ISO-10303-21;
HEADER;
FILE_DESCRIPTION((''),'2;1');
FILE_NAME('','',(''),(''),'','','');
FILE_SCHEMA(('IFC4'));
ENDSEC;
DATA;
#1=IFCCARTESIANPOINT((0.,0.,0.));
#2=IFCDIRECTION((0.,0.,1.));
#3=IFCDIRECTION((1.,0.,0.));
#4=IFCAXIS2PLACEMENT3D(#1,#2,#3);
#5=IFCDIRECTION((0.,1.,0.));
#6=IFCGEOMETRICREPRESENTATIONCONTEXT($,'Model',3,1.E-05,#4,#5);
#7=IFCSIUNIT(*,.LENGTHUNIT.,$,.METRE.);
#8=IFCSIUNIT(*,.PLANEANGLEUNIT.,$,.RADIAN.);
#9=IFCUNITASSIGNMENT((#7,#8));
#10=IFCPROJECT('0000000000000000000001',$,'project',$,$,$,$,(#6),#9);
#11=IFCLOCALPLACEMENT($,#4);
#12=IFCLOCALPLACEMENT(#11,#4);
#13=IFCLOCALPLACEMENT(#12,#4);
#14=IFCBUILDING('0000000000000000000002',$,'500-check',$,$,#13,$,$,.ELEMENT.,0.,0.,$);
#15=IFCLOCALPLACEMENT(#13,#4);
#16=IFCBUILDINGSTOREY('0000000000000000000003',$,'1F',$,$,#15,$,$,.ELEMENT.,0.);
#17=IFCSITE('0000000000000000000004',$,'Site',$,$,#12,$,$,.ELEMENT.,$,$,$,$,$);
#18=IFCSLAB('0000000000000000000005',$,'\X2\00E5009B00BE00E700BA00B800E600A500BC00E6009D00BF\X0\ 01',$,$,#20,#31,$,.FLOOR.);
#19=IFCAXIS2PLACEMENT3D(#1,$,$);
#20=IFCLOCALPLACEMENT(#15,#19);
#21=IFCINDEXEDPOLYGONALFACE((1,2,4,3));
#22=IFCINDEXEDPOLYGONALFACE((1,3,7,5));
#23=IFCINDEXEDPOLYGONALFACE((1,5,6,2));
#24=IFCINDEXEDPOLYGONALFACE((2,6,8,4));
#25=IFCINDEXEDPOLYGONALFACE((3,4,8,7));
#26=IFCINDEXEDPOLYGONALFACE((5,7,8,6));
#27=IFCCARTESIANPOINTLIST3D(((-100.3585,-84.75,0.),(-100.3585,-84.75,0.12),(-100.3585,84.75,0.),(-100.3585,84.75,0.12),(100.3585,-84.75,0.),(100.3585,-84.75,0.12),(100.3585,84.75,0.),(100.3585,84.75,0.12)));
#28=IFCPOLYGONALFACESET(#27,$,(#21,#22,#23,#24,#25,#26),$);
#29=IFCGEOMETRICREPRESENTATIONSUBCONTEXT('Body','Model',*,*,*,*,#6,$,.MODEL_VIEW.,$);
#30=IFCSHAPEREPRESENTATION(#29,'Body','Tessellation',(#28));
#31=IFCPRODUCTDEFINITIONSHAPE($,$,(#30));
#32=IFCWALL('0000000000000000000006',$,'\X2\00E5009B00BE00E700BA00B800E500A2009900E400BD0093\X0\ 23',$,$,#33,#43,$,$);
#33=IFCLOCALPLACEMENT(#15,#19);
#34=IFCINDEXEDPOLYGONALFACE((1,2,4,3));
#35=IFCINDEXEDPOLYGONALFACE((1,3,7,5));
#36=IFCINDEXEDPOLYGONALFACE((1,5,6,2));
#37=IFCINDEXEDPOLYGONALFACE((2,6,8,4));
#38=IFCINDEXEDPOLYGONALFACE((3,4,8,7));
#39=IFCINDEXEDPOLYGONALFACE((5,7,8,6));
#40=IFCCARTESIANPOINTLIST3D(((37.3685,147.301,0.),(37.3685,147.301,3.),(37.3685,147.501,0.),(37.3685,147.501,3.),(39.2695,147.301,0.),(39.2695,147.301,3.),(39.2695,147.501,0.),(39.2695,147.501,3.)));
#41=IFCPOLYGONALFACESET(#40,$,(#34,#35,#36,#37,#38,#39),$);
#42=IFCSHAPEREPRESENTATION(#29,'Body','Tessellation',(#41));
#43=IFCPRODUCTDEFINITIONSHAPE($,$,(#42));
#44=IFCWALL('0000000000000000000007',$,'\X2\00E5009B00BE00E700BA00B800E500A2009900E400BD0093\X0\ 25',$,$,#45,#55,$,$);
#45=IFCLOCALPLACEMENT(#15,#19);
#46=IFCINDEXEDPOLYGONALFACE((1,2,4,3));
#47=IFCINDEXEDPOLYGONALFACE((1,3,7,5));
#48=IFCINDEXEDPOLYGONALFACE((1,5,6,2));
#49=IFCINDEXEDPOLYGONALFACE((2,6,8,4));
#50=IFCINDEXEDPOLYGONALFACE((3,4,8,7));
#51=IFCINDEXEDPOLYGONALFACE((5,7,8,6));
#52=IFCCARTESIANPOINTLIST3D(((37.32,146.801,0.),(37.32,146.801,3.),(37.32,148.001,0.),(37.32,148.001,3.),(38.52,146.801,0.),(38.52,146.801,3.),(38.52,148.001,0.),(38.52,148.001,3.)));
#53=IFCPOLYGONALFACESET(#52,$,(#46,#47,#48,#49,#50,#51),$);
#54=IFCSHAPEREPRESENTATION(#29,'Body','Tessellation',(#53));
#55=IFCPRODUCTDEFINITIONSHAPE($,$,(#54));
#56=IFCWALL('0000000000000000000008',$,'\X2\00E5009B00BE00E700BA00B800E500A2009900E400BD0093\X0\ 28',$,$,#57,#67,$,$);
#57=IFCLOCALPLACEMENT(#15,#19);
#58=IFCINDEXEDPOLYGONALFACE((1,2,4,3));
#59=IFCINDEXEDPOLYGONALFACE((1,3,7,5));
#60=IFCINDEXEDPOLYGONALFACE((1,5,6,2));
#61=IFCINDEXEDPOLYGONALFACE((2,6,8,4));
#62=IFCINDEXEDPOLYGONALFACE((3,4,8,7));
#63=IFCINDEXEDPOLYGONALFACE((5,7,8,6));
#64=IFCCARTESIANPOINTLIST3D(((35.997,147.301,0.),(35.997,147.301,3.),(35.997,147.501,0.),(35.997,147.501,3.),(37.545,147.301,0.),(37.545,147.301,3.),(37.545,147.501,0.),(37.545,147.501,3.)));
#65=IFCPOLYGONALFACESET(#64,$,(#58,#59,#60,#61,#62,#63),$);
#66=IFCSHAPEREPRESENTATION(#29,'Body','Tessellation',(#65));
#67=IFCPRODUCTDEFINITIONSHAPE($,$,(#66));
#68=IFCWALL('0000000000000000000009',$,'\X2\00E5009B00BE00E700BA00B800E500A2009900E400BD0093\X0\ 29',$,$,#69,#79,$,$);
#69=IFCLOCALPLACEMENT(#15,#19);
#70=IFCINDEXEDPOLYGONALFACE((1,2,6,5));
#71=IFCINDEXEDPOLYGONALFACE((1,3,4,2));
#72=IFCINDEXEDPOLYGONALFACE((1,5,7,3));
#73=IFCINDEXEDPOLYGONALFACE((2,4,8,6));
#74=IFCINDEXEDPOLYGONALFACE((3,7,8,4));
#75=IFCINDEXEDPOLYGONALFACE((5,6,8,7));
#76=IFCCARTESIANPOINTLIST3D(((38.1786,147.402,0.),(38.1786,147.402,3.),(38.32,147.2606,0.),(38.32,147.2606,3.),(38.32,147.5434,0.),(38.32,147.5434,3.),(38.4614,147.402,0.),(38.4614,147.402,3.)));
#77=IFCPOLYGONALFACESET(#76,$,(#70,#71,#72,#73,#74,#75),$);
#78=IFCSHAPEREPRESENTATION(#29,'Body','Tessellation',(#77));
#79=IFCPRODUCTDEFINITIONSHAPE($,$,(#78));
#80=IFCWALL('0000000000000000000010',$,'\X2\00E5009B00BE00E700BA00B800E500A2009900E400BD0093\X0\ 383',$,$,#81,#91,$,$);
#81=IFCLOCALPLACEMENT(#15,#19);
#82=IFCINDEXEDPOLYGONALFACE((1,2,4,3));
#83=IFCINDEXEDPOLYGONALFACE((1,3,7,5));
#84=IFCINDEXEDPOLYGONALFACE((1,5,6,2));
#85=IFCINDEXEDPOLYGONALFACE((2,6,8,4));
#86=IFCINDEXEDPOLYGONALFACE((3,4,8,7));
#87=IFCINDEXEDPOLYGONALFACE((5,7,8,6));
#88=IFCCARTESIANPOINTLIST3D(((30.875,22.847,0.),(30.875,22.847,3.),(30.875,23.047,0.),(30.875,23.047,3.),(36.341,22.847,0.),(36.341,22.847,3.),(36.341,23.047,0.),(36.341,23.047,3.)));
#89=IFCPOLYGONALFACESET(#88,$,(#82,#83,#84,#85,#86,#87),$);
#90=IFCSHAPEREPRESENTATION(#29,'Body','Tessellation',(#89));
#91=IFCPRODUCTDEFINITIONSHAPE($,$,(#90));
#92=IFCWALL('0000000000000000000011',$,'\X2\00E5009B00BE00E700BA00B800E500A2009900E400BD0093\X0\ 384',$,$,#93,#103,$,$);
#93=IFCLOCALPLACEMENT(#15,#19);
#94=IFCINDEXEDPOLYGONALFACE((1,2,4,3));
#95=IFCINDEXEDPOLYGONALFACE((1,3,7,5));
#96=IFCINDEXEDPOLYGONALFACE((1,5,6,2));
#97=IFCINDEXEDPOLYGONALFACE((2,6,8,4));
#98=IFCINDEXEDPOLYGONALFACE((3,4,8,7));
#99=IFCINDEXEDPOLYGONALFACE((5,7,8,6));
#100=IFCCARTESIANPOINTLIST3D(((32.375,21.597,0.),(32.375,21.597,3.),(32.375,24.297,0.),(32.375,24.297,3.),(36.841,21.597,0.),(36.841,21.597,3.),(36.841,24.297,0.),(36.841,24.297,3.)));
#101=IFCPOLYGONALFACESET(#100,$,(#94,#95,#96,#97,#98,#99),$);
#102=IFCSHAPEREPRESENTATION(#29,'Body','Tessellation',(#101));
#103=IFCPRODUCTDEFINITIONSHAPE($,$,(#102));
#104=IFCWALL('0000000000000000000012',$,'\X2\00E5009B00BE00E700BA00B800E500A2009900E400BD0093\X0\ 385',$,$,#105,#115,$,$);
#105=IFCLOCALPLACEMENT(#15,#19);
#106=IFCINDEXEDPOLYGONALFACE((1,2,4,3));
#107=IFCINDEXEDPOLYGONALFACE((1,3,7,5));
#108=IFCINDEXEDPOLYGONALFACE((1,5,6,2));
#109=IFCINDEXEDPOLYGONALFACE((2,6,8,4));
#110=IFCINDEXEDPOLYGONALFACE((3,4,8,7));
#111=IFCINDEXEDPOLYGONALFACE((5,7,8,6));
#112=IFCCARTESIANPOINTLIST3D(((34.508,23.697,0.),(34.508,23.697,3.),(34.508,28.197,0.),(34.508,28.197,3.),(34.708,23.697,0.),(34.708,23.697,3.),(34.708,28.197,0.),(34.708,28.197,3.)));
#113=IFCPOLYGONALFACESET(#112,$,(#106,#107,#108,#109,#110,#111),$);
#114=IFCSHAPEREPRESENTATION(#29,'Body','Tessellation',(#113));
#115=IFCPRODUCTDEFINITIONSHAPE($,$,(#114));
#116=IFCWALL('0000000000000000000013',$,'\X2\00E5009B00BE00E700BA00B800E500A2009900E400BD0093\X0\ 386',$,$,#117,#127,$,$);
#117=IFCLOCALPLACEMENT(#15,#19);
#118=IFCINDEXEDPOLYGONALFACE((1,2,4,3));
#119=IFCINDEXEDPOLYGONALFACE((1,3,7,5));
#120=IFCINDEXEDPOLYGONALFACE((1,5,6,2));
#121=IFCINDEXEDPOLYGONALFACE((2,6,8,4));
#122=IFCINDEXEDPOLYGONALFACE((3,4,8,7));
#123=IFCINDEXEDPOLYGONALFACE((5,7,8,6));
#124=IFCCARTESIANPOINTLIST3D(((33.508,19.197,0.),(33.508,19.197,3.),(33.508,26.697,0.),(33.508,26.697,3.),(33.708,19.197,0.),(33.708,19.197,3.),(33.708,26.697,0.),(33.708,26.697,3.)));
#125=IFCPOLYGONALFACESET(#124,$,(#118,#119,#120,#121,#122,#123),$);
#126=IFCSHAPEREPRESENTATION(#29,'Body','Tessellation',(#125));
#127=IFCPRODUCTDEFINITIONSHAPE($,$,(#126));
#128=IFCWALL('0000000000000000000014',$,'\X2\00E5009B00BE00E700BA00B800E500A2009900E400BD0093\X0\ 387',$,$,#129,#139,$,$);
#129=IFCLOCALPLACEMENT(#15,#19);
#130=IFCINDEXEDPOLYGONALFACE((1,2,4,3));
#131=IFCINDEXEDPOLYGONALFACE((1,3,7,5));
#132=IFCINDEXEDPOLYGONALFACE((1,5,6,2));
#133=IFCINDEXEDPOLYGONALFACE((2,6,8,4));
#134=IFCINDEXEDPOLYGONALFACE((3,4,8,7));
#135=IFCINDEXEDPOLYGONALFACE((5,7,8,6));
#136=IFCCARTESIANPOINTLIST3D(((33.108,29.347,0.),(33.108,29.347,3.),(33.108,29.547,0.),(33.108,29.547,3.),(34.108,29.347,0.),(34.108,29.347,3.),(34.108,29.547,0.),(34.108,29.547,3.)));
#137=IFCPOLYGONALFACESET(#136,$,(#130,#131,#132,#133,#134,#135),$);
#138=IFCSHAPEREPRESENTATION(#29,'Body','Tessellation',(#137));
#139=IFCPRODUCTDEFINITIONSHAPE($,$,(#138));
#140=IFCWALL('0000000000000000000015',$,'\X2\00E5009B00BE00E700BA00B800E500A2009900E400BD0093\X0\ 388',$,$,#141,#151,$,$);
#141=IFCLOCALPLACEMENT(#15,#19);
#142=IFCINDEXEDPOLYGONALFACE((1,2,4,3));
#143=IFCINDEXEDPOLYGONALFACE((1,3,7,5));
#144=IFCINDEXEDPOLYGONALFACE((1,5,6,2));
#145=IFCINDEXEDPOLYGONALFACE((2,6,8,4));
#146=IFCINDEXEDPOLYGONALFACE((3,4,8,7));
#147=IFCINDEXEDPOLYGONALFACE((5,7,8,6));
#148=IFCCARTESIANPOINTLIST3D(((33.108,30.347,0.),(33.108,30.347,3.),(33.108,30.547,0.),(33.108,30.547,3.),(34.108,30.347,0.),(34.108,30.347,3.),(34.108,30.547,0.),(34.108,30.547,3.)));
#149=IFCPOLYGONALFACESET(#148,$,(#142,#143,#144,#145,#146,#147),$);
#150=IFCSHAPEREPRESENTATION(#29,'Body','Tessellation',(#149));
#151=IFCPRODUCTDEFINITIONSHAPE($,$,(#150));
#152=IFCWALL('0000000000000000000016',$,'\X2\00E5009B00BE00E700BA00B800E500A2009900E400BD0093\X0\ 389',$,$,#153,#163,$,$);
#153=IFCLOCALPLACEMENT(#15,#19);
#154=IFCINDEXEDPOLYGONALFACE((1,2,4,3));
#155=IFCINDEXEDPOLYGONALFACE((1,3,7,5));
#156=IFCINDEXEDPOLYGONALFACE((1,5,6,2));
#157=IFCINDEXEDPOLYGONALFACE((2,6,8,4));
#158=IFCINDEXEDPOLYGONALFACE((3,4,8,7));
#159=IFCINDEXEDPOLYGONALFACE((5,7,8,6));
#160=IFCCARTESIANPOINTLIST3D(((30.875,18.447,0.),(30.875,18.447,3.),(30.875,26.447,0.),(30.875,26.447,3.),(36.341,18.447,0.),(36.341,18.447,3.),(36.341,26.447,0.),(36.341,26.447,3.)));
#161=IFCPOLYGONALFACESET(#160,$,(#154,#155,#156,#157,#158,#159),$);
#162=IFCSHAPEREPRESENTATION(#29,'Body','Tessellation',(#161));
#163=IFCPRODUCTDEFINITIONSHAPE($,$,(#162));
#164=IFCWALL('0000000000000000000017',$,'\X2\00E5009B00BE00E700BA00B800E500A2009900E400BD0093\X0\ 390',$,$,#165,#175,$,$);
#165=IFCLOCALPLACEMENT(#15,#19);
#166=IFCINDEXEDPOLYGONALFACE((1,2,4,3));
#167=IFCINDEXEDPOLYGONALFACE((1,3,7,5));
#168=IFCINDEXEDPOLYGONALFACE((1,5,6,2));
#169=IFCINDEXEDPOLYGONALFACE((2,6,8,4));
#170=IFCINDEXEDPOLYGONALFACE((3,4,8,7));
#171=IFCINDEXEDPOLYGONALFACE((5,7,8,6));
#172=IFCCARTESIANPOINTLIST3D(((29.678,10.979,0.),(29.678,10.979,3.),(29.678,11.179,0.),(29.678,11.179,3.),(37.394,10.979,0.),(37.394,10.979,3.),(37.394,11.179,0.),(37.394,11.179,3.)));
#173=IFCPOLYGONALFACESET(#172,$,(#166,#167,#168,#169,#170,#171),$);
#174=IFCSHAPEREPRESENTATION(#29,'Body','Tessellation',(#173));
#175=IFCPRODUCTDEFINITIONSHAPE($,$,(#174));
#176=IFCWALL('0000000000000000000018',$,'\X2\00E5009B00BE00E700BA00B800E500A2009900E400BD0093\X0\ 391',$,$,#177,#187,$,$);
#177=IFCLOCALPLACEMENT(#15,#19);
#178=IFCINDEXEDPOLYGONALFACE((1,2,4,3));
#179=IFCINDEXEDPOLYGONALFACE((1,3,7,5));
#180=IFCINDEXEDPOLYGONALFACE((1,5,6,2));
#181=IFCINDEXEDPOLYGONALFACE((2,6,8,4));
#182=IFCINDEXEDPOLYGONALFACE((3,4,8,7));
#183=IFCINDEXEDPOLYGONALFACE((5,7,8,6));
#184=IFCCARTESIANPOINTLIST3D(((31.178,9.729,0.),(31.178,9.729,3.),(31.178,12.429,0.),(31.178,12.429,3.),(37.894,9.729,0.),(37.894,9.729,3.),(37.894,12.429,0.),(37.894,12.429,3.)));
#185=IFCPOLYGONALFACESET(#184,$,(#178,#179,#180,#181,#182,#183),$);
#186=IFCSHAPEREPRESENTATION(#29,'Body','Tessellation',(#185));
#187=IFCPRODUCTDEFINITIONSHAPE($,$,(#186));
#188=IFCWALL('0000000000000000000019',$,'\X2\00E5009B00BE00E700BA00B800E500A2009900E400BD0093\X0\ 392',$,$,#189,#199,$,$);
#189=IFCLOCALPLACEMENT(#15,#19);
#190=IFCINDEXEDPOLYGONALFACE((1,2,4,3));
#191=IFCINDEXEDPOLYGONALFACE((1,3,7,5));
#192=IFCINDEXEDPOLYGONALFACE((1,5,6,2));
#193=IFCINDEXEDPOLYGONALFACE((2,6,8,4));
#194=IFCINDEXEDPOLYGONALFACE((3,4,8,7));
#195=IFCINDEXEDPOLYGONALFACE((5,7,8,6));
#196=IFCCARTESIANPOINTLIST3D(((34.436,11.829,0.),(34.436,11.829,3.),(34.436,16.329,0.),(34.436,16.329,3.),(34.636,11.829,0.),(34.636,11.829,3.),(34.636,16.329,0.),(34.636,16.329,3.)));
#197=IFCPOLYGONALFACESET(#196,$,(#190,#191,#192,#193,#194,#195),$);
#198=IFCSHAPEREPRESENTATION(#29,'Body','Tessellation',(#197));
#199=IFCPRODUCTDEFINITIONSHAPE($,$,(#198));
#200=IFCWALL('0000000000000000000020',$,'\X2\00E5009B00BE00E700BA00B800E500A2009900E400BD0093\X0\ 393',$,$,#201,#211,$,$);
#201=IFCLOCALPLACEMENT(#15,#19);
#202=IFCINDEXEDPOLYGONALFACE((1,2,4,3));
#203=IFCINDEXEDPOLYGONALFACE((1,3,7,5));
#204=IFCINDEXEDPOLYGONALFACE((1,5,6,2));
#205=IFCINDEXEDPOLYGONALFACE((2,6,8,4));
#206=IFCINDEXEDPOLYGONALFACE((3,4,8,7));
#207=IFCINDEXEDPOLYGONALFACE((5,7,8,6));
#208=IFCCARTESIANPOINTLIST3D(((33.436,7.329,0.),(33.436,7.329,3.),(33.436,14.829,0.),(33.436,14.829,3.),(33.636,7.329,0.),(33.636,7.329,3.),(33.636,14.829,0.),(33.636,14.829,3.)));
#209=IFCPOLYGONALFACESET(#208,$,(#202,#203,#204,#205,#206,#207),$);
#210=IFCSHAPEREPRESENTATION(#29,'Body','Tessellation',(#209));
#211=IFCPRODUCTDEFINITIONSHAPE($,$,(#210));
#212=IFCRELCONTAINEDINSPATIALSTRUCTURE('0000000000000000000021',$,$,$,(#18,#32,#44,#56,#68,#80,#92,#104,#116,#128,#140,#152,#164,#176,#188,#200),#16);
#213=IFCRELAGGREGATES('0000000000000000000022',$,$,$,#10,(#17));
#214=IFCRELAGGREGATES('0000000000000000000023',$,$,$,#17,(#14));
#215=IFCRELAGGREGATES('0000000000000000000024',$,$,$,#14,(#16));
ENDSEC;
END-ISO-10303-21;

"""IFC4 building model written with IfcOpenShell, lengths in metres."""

from ifc_helpers import new_model, si_unit, direction, frame, frame_2d, origin_with_axes, place, context, subcontext, project, spatial, rectangle, extrude, element, save


model = new_model("IFC4")

# Units and contexts
model_context = context("Model", 3, precision=1e-05, world=origin_with_axes(), true_north=direction((0.0, 1.0, 0.0)))
body_context = subcontext(model_context, "Body", "Model", "MODEL_VIEW")
ifc_project = project(units=[si_unit("LENGTHUNIT", "METRE"), si_unit("PLANEANGLEUNIT", "RADIAN")], contexts=[model_context])

# Site, building, storey
placement = place(None, origin_with_axes())
site_placement = place(placement, origin_with_axes())
site = spatial("IfcSite", under=ifc_project, at=site_placement, Name="Site", CompositionType="ELEMENT")
building_placement = place(site_placement, origin_with_axes())
building = spatial("IfcBuilding", under=site, at=building_placement, Name="500-check", CompositionType="ELEMENT", ElevationOfRefHeight=0.0, ElevationOfTerrain=0.0)
storey_placement = place(building_placement, origin_with_axes())
storey = spatial("IfcBuildingStorey", under=building, at=storey_placement, Name="1F", CompositionType="ELEMENT", Elevation=0.0)

# Slab
slab_placement = place(storey_placement, origin_with_axes())
element("IfcSlab", 1, at=slab_placement, inside=storey, Name="å\u009b¾çº¸æ¥¼æ\u009d¿ 01", PredefinedType="FLOOR", context=body_context, shape_type="SweptSolid", body=[
    extrude(rectangle(XDim=200.717, YDim=169.5, at=frame_2d((0.0, 0.0), x_axis=(1.0, 0.0, 0.0))), frame((0.0, 0.0, 0.0), z_axis=(0.0, 0.0, 1.0)), (0.0, 0.0, 1.0), 0.12),
])

# Walls
wall_1_placement = place(storey_placement, frame((38.319, 147.401, 0.0), z_axis=(0.0, 0.0, 1.0), x_axis=(1.0, 0.0, 0.0)))
element("IfcWall", 2, at=wall_1_placement, inside=storey, Name="å\u009b¾çº¸å¢\u0099ä½\u0093 23", context=body_context, shape_type="SweptSolid", body=[
    extrude(rectangle(XDim=1.901, YDim=0.2, at=frame_2d((0.0, 0.0), x_axis=(1.0, 0.0, 0.0))), frame((0.0, 0.0, 0.0), z_axis=(0.0, 0.0, 1.0)), (0.0, 0.0, 1.0), 3.0),
])
wall_2_placement = place(storey_placement, frame((37.92, 147.401, 0.0), z_axis=(0.0, 0.0, 1.0), x_axis=(1.0, 0.0, 0.0)))
element("IfcWall", 3, at=wall_2_placement, inside=storey, Name="å\u009b¾çº¸å¢\u0099ä½\u0093 25", context=body_context, shape_type="SweptSolid", body=[
    extrude(rectangle(XDim=1.2, YDim=1.2, at=frame_2d((0.0, 0.0), x_axis=(1.0, 0.0, 0.0))), frame((0.0, 0.0, 0.0), z_axis=(0.0, 0.0, 1.0)), (0.0, 0.0, 1.0), 3.0),
])
wall_3_placement = place(storey_placement, frame((36.771, 147.401, 0.0), z_axis=(0.0, 0.0, 1.0), x_axis=(1.0, 0.0, 0.0)))
element("IfcWall", 4, at=wall_3_placement, inside=storey, Name="å\u009b¾çº¸å¢\u0099ä½\u0093 28", context=body_context, shape_type="SweptSolid", body=[
    extrude(rectangle(XDim=1.548, YDim=0.2, at=frame_2d((0.0, 0.0), x_axis=(1.0, 0.0, 0.0))), frame((0.0, 0.0, 0.0), z_axis=(0.0, 0.0, 1.0)), (0.0, 0.0, 1.0), 3.0),
])
wall_4_placement = place(storey_placement, frame((38.32, 147.402, 0.0), z_axis=(0.0, 0.0, 1.0), x_axis=(-0.707107, -0.707107, 0.0)))
element("IfcWall", 5, at=wall_4_placement, inside=storey, Name="å\u009b¾çº¸å¢\u0099ä½\u0093 29", context=body_context, shape_type="SweptSolid", body=[
    extrude(rectangle(XDim=0.2, YDim=0.2, at=frame_2d((0.0, 0.0), x_axis=(1.0, 0.0, 0.0))), frame((0.0, 0.0, 0.0), z_axis=(0.0, 0.0, 1.0)), (0.0, 0.0, 1.0), 3.0),
])
wall_5_placement = place(storey_placement, frame((33.608, 22.947, 0.0), z_axis=(0.0, 0.0, 1.0), x_axis=(1.0, 0.0, 0.0)))
element("IfcWall", 6, at=wall_5_placement, inside=storey, Name="å\u009b¾çº¸å¢\u0099ä½\u0093 383", context=body_context, shape_type="SweptSolid", body=[
    extrude(rectangle(XDim=5.466, YDim=0.2, at=frame_2d((0.0, 0.0), x_axis=(1.0, 0.0, 0.0))), frame((0.0, 0.0, 0.0), z_axis=(0.0, 0.0, 1.0)), (0.0, 0.0, 1.0), 3.0),
])
wall_6_placement = place(storey_placement, frame((34.608, 22.947, 0.0), z_axis=(0.0, 0.0, 1.0), x_axis=(1.0, 0.0, 0.0)))
element("IfcWall", 7, at=wall_6_placement, inside=storey, Name="å\u009b¾çº¸å¢\u0099ä½\u0093 384", context=body_context, shape_type="SweptSolid", body=[
    extrude(rectangle(XDim=4.466, YDim=2.7, at=frame_2d((0.0, 0.0), x_axis=(1.0, 0.0, 0.0))), frame((0.0, 0.0, 0.0), z_axis=(0.0, 0.0, 1.0)), (0.0, 0.0, 1.0), 3.0),
])
wall_7_placement = place(storey_placement, frame((34.608, 25.947, 0.0), z_axis=(0.0, 0.0, 1.0), x_axis=(0.0, 1.0, 0.0)))
element("IfcWall", 8, at=wall_7_placement, inside=storey, Name="å\u009b¾çº¸å¢\u0099ä½\u0093 385", context=body_context, shape_type="SweptSolid", body=[
    extrude(rectangle(XDim=4.5, YDim=0.2, at=frame_2d((0.0, 0.0), x_axis=(1.0, 0.0, 0.0))), frame((0.0, 0.0, 0.0), z_axis=(0.0, 0.0, 1.0)), (0.0, 0.0, 1.0), 3.0),
])
wall_8_placement = place(storey_placement, frame((33.608, 22.947, 0.0), z_axis=(0.0, 0.0, 1.0), x_axis=(0.0, 1.0, 0.0)))
element("IfcWall", 9, at=wall_8_placement, inside=storey, Name="å\u009b¾çº¸å¢\u0099ä½\u0093 386", context=body_context, shape_type="SweptSolid", body=[
    extrude(rectangle(XDim=7.5, YDim=0.2, at=frame_2d((0.0, 0.0), x_axis=(1.0, 0.0, 0.0))), frame((0.0, 0.0, 0.0), z_axis=(0.0, 0.0, 1.0)), (0.0, 0.0, 1.0), 3.0),
])
for number, where, z_axis, x_axis, name in (
    (10, (33.608, 29.447, 0.0), (0.0, 0.0, 1.0), (1.0, 0.0, 0.0), "å\u009b¾çº¸å¢\u0099ä½\u0093 387"),
    (11, (33.608, 30.447, 0.0), (0.0, 0.0, 1.0), (1.0, 0.0, 0.0), "å\u009b¾çº¸å¢\u0099ä½\u0093 388"),
):
    element("IfcWall", number, at=place(storey_placement, frame(where, z_axis=z_axis, x_axis=x_axis)), inside=storey, Name=name, context=body_context, shape_type="SweptSolid", body=[
        extrude(rectangle(XDim=1.0, YDim=0.2, at=frame_2d((0.0, 0.0), x_axis=(1.0, 0.0, 0.0))), frame((0.0, 0.0, 0.0), z_axis=(0.0, 0.0, 1.0)), (0.0, 0.0, 1.0), 3.0),
    ])
wall_9_placement = place(storey_placement, frame((33.608, 22.447, 0.0), z_axis=(0.0, 0.0, 1.0), x_axis=(1.0, 0.0, 0.0)))
element("IfcWall", 12, at=wall_9_placement, inside=storey, Name="å\u009b¾çº¸å¢\u0099ä½\u0093 389", context=body_context, shape_type="SweptSolid", body=[
    extrude(rectangle(XDim=5.466, YDim=8.0, at=frame_2d((0.0, 0.0), x_axis=(1.0, 0.0, 0.0))), frame((0.0, 0.0, 0.0), z_axis=(0.0, 0.0, 1.0)), (0.0, 0.0, 1.0), 3.0),
])
wall_10_placement = place(storey_placement, frame((33.536, 11.079, 0.0), z_axis=(0.0, 0.0, 1.0), x_axis=(1.0, 0.0, 0.0)))
element("IfcWall", 13, at=wall_10_placement, inside=storey, Name="å\u009b¾çº¸å¢\u0099ä½\u0093 390", context=body_context, shape_type="SweptSolid", body=[
    extrude(rectangle(XDim=7.716, YDim=0.2, at=frame_2d((0.0, 0.0), x_axis=(1.0, 0.0, 0.0))), frame((0.0, 0.0, 0.0), z_axis=(0.0, 0.0, 1.0)), (0.0, 0.0, 1.0), 3.0),
])
wall_11_placement = place(storey_placement, frame((34.536, 11.079, 0.0), z_axis=(0.0, 0.0, 1.0), x_axis=(1.0, 0.0, 0.0)))
element("IfcWall", 14, at=wall_11_placement, inside=storey, Name="å\u009b¾çº¸å¢\u0099ä½\u0093 391", context=body_context, shape_type="SweptSolid", body=[
    extrude(rectangle(XDim=6.716, YDim=2.7, at=frame_2d((0.0, 0.0), x_axis=(1.0, 0.0, 0.0))), frame((0.0, 0.0, 0.0), z_axis=(0.0, 0.0, 1.0)), (0.0, 0.0, 1.0), 3.0),
])
wall_12_placement = place(storey_placement, frame((34.536, 14.079, 0.0), z_axis=(0.0, 0.0, 1.0), x_axis=(0.0, 1.0, 0.0)))
element("IfcWall", 15, at=wall_12_placement, inside=storey, Name="å\u009b¾çº¸å¢\u0099ä½\u0093 392", context=body_context, shape_type="SweptSolid", body=[
    extrude(rectangle(XDim=4.5, YDim=0.2, at=frame_2d((0.0, 0.0), x_axis=(1.0, 0.0, 0.0))), frame((0.0, 0.0, 0.0), z_axis=(0.0, 0.0, 1.0)), (0.0, 0.0, 1.0), 3.0),
])
wall_13_placement = place(storey_placement, frame((33.536, 11.079, 0.0), z_axis=(0.0, 0.0, 1.0), x_axis=(0.0, 1.0, 0.0)))
element("IfcWall", 16, at=wall_13_placement, inside=storey, Name="å\u009b¾çº¸å¢\u0099ä½\u0093 393", context=body_context, shape_type="SweptSolid", body=[
    extrude(rectangle(XDim=7.5, YDim=0.2, at=frame_2d((0.0, 0.0), x_axis=(1.0, 0.0, 0.0))), frame((0.0, 0.0, 0.0), z_axis=(0.0, 0.0, 1.0)), (0.0, 0.0, 1.0), 3.0),
])

save(model, "model.ifc")
